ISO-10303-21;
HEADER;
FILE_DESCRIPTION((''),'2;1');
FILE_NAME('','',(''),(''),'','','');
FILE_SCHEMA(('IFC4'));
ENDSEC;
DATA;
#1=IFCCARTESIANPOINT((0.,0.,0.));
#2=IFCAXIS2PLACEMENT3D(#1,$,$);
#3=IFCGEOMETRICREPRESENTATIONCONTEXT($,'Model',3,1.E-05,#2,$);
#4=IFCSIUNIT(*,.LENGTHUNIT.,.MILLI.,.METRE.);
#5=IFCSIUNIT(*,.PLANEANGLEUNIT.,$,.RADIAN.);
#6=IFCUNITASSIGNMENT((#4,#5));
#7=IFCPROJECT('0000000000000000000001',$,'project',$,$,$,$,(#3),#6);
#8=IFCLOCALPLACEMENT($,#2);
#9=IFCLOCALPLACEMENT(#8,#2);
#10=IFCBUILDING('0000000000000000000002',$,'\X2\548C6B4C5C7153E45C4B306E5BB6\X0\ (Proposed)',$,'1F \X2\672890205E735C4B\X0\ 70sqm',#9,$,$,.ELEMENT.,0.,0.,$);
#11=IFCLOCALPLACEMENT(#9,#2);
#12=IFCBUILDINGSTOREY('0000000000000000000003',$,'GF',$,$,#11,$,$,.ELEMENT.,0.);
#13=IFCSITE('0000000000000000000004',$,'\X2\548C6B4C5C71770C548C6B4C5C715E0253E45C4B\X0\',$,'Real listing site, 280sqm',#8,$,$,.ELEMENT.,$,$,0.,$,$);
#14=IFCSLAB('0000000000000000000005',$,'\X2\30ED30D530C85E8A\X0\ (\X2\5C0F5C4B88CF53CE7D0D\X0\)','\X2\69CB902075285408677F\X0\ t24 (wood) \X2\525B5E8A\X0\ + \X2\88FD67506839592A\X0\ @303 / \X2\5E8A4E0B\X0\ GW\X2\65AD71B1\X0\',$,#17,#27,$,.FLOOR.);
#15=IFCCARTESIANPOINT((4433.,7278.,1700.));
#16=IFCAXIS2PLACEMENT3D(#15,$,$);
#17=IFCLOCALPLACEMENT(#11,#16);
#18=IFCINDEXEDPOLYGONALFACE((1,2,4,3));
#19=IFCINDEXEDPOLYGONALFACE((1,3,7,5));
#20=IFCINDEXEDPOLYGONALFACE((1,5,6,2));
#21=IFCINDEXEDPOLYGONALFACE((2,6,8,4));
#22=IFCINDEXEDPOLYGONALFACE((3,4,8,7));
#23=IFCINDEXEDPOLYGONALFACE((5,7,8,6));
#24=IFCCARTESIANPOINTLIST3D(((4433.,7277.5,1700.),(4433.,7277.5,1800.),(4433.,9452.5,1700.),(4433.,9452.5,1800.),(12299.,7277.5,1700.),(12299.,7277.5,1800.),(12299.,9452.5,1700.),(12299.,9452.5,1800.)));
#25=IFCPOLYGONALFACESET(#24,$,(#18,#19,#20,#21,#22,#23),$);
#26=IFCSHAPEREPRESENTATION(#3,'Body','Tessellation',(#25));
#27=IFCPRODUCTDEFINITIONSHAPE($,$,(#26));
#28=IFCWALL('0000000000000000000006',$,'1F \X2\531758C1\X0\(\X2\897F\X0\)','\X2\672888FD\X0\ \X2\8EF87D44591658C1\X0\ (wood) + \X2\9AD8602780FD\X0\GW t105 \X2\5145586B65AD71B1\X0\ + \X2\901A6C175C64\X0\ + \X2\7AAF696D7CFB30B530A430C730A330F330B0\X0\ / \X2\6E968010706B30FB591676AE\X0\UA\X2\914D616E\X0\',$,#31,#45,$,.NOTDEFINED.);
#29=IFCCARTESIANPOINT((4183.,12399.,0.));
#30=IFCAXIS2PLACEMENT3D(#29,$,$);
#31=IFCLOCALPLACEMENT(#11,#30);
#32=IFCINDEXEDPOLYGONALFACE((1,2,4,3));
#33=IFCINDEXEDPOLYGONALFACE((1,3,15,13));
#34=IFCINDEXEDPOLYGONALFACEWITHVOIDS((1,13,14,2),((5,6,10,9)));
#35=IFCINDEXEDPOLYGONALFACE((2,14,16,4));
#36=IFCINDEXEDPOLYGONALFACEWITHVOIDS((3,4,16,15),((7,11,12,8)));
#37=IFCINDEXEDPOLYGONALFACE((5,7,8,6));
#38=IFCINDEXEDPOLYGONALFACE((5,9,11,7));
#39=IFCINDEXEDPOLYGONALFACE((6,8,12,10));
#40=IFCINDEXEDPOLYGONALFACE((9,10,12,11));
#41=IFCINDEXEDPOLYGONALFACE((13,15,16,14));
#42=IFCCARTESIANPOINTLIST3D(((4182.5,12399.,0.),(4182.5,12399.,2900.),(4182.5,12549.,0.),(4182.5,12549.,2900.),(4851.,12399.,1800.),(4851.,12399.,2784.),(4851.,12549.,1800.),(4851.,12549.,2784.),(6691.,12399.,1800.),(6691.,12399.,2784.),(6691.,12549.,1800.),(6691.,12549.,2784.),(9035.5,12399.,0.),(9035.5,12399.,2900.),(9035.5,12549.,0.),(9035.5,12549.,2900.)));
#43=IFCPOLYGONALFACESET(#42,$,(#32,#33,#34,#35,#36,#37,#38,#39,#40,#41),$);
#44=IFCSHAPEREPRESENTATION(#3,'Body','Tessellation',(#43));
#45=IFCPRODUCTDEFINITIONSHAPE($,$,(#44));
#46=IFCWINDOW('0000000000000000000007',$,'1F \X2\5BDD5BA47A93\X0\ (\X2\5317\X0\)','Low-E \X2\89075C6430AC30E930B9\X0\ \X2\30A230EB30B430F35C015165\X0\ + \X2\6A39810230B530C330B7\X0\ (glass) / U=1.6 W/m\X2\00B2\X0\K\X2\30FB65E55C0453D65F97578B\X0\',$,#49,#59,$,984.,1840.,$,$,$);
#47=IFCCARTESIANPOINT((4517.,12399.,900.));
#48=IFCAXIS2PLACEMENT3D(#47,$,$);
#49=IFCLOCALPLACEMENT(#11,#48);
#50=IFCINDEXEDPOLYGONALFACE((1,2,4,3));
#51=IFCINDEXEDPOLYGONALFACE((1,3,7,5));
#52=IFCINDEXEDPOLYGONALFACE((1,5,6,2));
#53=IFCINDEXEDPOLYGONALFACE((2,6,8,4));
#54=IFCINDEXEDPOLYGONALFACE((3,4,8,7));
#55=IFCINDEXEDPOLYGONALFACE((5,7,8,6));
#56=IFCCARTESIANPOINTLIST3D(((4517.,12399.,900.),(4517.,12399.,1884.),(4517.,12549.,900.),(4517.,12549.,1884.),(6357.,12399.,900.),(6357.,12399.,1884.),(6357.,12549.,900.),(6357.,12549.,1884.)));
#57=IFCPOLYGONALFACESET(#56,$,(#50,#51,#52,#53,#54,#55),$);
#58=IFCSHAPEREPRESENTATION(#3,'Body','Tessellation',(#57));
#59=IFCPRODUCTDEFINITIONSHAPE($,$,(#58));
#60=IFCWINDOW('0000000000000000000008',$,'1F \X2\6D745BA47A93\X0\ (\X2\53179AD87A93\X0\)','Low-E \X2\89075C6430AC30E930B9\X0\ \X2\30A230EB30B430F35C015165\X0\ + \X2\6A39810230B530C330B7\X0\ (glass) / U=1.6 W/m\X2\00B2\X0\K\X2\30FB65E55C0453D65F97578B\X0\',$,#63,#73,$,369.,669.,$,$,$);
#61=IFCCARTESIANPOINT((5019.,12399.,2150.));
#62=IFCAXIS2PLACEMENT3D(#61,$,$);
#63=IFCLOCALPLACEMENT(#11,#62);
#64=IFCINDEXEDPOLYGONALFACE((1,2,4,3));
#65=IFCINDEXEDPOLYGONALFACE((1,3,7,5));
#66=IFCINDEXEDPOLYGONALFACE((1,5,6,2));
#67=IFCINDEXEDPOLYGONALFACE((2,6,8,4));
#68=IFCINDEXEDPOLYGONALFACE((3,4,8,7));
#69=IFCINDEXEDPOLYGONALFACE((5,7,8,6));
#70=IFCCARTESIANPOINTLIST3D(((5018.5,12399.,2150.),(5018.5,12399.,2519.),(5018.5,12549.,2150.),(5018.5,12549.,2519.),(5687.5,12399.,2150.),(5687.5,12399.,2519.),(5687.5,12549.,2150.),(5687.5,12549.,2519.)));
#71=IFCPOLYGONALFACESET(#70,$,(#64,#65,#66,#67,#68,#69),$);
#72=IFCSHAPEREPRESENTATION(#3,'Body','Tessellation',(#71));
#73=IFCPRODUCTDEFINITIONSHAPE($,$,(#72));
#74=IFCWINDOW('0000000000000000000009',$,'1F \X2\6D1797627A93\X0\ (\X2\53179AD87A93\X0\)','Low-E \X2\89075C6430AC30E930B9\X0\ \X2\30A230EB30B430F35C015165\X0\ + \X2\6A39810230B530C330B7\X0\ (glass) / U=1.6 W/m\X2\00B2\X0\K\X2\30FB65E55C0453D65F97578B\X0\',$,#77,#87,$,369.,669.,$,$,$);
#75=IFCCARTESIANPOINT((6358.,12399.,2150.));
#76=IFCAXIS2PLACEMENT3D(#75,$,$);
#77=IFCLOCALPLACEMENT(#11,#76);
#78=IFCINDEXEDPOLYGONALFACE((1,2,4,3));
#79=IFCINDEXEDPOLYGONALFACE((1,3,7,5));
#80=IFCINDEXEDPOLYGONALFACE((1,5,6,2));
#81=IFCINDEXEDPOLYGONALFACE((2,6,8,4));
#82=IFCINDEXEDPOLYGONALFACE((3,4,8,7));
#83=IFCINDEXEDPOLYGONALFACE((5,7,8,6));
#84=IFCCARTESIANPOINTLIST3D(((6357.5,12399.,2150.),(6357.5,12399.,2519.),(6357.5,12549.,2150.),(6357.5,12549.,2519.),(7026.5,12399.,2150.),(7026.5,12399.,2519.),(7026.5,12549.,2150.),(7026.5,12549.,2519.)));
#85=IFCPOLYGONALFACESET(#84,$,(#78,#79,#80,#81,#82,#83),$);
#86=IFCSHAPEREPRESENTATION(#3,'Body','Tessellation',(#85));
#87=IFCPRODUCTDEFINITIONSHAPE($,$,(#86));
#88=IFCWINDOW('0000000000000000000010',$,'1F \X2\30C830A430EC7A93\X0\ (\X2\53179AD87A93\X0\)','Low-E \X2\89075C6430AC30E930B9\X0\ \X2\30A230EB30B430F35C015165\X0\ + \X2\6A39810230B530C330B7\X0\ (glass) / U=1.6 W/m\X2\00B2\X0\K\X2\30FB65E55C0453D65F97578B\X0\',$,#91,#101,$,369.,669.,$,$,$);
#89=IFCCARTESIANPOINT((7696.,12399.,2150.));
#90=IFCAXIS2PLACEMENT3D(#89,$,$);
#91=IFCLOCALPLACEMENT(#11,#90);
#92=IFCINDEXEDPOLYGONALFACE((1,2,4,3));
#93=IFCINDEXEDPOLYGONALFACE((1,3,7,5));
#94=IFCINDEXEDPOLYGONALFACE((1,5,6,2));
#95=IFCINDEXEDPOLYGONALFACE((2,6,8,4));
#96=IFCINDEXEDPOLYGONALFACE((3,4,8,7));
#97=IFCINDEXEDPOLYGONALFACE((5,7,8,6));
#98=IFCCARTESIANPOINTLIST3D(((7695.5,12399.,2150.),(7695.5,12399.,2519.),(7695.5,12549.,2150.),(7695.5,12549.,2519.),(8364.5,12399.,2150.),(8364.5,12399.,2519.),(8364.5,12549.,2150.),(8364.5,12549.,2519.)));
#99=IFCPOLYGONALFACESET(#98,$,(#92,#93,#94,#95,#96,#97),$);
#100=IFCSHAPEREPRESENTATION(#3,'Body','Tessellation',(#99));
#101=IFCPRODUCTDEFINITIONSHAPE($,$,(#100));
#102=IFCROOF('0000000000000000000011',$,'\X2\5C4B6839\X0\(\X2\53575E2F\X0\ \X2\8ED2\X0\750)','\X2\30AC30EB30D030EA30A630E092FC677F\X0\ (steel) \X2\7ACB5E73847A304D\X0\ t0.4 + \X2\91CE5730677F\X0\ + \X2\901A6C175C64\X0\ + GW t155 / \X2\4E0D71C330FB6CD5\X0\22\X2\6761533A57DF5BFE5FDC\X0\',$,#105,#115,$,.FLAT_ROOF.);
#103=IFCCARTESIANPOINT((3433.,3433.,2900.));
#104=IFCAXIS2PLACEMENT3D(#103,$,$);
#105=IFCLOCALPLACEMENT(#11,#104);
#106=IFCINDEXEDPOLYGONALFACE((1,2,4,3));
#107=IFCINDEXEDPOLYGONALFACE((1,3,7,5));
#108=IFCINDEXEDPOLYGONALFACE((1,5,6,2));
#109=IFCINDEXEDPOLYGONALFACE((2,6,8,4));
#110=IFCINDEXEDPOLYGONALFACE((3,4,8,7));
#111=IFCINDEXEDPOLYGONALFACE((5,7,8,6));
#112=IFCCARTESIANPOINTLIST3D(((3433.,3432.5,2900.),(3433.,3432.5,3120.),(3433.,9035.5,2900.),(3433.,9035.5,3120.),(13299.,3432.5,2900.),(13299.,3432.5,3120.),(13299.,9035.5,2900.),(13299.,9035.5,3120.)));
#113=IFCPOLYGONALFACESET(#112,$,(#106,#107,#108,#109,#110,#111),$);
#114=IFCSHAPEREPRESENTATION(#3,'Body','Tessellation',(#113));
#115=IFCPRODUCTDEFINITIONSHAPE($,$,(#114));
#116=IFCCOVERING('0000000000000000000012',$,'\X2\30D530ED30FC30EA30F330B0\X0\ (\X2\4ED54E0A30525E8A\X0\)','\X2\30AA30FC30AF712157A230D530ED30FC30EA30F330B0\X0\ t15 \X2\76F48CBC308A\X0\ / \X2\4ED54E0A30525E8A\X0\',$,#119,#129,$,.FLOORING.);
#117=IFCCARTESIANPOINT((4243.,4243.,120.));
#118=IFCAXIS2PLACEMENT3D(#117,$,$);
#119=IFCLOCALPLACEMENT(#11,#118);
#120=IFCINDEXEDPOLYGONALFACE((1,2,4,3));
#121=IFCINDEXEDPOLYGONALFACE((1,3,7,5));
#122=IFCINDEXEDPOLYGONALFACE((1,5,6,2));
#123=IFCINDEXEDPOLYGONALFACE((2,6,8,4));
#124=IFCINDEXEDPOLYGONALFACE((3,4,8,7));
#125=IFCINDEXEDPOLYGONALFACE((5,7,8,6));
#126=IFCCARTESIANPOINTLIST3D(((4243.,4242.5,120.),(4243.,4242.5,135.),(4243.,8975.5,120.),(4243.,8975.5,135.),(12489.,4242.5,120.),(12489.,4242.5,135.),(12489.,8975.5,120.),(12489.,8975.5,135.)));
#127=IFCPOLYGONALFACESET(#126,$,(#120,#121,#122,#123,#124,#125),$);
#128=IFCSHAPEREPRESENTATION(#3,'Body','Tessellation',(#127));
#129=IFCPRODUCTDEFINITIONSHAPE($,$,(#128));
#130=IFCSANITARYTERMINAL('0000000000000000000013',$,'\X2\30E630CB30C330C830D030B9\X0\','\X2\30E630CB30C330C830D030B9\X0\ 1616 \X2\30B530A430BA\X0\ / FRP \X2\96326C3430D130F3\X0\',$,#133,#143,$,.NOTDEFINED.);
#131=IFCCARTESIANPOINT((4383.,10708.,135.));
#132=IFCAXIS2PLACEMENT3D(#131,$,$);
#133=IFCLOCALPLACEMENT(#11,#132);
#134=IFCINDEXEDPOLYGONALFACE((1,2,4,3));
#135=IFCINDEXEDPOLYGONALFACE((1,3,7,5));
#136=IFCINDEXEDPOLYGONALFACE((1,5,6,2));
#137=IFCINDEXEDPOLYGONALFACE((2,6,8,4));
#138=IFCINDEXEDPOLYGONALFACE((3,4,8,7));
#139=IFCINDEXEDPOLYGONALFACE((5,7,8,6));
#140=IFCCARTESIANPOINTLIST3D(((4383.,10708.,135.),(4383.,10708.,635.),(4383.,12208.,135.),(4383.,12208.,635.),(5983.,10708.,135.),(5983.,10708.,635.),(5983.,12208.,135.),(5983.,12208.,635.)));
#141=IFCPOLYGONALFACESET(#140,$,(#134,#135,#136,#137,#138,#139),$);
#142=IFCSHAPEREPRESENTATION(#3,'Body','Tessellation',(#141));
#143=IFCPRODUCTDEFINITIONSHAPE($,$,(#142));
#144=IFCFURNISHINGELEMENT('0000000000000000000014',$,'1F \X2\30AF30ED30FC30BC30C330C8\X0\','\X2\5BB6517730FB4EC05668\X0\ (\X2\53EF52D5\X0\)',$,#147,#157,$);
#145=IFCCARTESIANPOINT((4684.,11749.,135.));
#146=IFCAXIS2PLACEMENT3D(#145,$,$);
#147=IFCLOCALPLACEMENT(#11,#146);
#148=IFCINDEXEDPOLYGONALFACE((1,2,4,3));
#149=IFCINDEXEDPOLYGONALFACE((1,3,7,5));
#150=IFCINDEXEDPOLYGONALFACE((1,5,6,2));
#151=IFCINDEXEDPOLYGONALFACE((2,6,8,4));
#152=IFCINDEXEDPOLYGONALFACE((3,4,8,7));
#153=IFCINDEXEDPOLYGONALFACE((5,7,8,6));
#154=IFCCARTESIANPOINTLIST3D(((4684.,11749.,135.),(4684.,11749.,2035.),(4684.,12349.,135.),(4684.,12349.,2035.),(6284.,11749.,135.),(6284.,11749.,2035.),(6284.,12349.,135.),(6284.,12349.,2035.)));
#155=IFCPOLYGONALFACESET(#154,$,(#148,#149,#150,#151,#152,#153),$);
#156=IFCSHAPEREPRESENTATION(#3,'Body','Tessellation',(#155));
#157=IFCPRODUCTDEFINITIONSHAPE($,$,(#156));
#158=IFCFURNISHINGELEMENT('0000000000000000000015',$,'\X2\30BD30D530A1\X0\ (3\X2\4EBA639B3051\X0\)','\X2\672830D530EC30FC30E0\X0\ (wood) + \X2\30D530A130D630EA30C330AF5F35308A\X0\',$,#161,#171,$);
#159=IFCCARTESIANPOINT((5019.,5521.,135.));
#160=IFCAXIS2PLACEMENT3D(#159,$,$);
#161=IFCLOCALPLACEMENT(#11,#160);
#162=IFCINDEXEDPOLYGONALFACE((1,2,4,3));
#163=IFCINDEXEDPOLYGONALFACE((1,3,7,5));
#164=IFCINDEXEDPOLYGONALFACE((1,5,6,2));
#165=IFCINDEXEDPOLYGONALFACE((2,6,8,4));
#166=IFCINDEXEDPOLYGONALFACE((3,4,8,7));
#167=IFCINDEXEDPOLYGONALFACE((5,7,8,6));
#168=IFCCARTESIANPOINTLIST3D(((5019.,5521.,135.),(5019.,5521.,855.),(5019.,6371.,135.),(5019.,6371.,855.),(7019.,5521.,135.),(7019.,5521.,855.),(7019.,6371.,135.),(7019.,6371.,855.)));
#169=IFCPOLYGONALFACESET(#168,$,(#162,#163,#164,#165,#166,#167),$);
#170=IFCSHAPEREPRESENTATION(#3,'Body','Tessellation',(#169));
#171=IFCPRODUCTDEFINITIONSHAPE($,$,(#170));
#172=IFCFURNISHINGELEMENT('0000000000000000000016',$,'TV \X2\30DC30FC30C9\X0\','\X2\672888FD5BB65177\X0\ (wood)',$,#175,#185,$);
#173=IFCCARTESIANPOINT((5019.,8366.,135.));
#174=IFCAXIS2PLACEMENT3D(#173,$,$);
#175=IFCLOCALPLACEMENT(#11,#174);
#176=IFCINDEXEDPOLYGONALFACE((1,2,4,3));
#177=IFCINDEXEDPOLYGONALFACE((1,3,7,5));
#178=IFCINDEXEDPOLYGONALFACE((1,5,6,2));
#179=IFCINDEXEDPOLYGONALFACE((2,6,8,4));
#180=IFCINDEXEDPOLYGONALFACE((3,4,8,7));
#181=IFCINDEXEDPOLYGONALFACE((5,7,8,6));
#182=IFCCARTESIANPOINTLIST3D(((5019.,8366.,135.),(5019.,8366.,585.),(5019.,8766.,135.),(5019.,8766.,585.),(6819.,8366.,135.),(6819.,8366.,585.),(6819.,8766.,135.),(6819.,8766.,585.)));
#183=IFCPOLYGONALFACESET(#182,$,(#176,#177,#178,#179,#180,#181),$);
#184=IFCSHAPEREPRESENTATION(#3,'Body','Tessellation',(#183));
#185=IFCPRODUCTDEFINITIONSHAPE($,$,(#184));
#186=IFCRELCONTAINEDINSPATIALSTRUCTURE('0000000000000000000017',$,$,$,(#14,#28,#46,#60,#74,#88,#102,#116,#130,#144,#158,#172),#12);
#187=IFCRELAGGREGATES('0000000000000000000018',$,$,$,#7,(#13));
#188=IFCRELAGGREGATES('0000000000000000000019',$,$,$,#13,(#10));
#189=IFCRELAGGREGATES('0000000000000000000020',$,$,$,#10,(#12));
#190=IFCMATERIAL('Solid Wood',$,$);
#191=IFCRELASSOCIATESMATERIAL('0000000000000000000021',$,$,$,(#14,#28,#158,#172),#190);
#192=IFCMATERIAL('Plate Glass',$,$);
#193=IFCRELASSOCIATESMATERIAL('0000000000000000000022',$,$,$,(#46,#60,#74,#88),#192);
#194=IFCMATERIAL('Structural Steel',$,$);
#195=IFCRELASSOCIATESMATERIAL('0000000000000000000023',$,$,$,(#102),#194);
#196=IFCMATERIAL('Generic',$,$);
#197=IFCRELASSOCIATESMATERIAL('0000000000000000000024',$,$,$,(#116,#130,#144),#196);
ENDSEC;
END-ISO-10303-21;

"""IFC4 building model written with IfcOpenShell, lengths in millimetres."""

from ifc_helpers import new_model, si_unit, frame, frame_2d, origin, place, context, project, spatial, rectangle, extrude, material, element, fill, save


model = new_model("IFC4")

# Units and contexts
model_context = context("Model", 3, precision=1e-05, world=origin())
ifc_project = project(units=[si_unit("LENGTHUNIT", "METRE", prefix="MILLI"), si_unit("PLANEANGLEUNIT", "RADIAN")], contexts=[model_context])

# Site, building, storey
site_placement = place(None, origin())
site = spatial("IfcSite", under=ifc_project, at=site_placement, Name="和歌山県和歌山市古屋", ObjectType="Real listing site, 280sqm", CompositionType="ELEMENT", RefElevation=0.0)
building_placement = place(site_placement, origin())
building = spatial("IfcBuilding", under=site, at=building_placement, Name="和歌山古屋の家 (Proposed)", ObjectType="1F 木造平屋 70sqm", CompositionType="ELEMENT", ElevationOfRefHeight=0.0, ElevationOfTerrain=0.0)
storey_placement = place(building_placement, origin())
storey = spatial("IfcBuildingStorey", under=building, at=storey_placement, Name="GF", CompositionType="ELEMENT", Elevation=0.0)

# Slab
ifc_material_1 = material(Name="Solid Wood")
slab_1_placement = place(storey_placement, frame((4433.0, 7278.0, 1700.0)))
element("IfcSlab", 1, at=slab_1_placement, inside=storey, material=ifc_material_1, Name="ロフト床 (小屋裏収納)", Description="構造用合板 t24 (wood) 剛床 + 製材根太 @303 / 床下 GW断熱", PredefinedType="FLOOR", context=model_context, shape_type="SweptSolid", body=[
    extrude(rectangle(XDim=7866.0, YDim=2175.0, at=frame_2d((3933.0, 1087.0))), frame((4433.0, 7278.0, 1700.0)), (0.0, 0.0, 1.0), 100.0),
])

# Shared definitions
ifc_material_2 = material(Name="Plate Glass")

# Wall, openings, windows
wall_1_placement = place(storey_placement, frame((4183.0, 12399.0, 0.0)))
wall_1 = element("IfcWall", 2, at=wall_1_placement, inside=storey, material=ifc_material_1, Name="1F 北壁(西)", Description="木製 軸組外壁 (wood) + 高性能GW t105 充填断熱 + 通気層 + 窯業系サイディング / 準耐火・外皮UA配慮", PredefinedType="NOTDEFINED", context=model_context, shape_type="SweptSolid", body=[
    extrude(rectangle(XDim=4853.0, YDim=150.0, at=frame_2d((2426.0, 75.0))), frame((4183.0, 12399.0, 0.0)), (0.0, 0.0, 1.0), 2900.0),
])
opening_1_placement = place(storey_placement, frame((4517.0, 12399.0, 900.0)))
opening_1 = element("IfcOpeningElement", 3, at=opening_1_placement, cuts=wall_1, PredefinedType="NOTDEFINED", context=model_context, shape_type="SweptSolid", body=[
    extrude(rectangle(XDim=1840.0, YDim=150.0, at=frame_2d((920.0, 75.0))), frame((4517.0, 12399.0, 900.0)), (0.0, 0.0, 1.0), 984.0),
])
opening_2_placement = place(storey_placement, frame((5019.0, 12399.0, 2150.0)))
opening_2 = element("IfcOpeningElement", 4, at=opening_2_placement, cuts=wall_1, PredefinedType="NOTDEFINED", context=model_context, shape_type="SweptSolid", body=[
    extrude(rectangle(XDim=669.0, YDim=150.0, at=frame_2d((334.0, 75.0))), frame((5019.0, 12399.0, 2150.0)), (0.0, 0.0, 1.0), 369.0),
])
opening_3_placement = place(storey_placement, frame((6358.0, 12399.0, 2150.0)))
opening_3 = element("IfcOpeningElement", 5, at=opening_3_placement, cuts=wall_1, PredefinedType="NOTDEFINED", context=model_context, shape_type="SweptSolid", body=[
    extrude(rectangle(XDim=669.0, YDim=150.0, at=frame_2d((334.0, 75.0))), frame((6358.0, 12399.0, 2150.0)), (0.0, 0.0, 1.0), 369.0),
])
opening_4_placement = place(storey_placement, frame((7696.0, 12399.0, 2150.0)))
opening_4 = element("IfcOpeningElement", 6, at=opening_4_placement, cuts=wall_1, PredefinedType="NOTDEFINED", context=model_context, shape_type="SweptSolid", body=[
    extrude(rectangle(XDim=669.0, YDim=150.0, at=frame_2d((334.0, 75.0))), frame((7696.0, 12399.0, 2150.0)), (0.0, 0.0, 1.0), 369.0),
])
window_1_placement = place(storey_placement, frame((4517.0, 12399.0, 900.0)))
window_1 = element("IfcWindow", 7, at=window_1_placement, inside=storey, material=ifc_material_2, Name="1F 寝室窓 (北)", Description="Low-E 複層ガラス アルゴン封入 + 樹脂サッシ (glass) / U=1.6 W/m²K・日射取得型", OverallHeight=984.0, OverallWidth=1840.0, context=model_context, shape_type="SweptSolid", body=[
    extrude(rectangle(XDim=1840.0, YDim=150.0, at=frame_2d((920.0, 75.0))), frame((4517.0, 12399.0, 900.0)), (0.0, 0.0, 1.0), 984.0),
])
fill(opening_1, window_1)
window_2_placement = place(storey_placement, frame((5019.0, 12399.0, 2150.0)))
window_2 = element("IfcWindow", 8, at=window_2_placement, inside=storey, material=ifc_material_2, Name="1F 浴室窓 (北高窓)", Description="Low-E 複層ガラス アルゴン封入 + 樹脂サッシ (glass) / U=1.6 W/m²K・日射取得型", OverallHeight=369.0, OverallWidth=669.0, context=model_context, shape_type="SweptSolid", body=[
    extrude(rectangle(XDim=669.0, YDim=150.0, at=frame_2d((334.0, 75.0))), frame((5019.0, 12399.0, 2150.0)), (0.0, 0.0, 1.0), 369.0),
])
fill(opening_2, window_2)
window_3_placement = place(storey_placement, frame((6358.0, 12399.0, 2150.0)))
window_3 = element("IfcWindow", 9, at=window_3_placement, inside=storey, material=ifc_material_2, Name="1F 洗面窓 (北高窓)", Description="Low-E 複層ガラス アルゴン封入 + 樹脂サッシ (glass) / U=1.6 W/m²K・日射取得型", OverallHeight=369.0, OverallWidth=669.0, context=model_context, shape_type="SweptSolid", body=[
    extrude(rectangle(XDim=669.0, YDim=150.0, at=frame_2d((334.0, 75.0))), frame((6358.0, 12399.0, 2150.0)), (0.0, 0.0, 1.0), 369.0),
])
fill(opening_3, window_3)
window_4_placement = place(storey_placement, frame((7696.0, 12399.0, 2150.0)))
window_4 = element("IfcWindow", 10, at=window_4_placement, inside=storey, material=ifc_material_2, Name="1F トイレ窓 (北高窓)", Description="Low-E 複層ガラス アルゴン封入 + 樹脂サッシ (glass) / U=1.6 W/m²K・日射取得型", OverallHeight=369.0, OverallWidth=669.0, context=model_context, shape_type="SweptSolid", body=[
    extrude(rectangle(XDim=669.0, YDim=150.0, at=frame_2d((334.0, 75.0))), frame((7696.0, 12399.0, 2150.0)), (0.0, 0.0, 1.0), 369.0),
])
fill(opening_4, window_4)

# Roof
ifc_material_3 = material(Name="Structural Steel")
roof_1_placement = place(storey_placement, frame((3433.0, 3433.0, 2900.0)))
element("IfcRoof", 11, at=roof_1_placement, inside=storey, material=ifc_material_3, Name="屋根(南帯 軒750)", Description="ガルバリウム鋼板 (steel) 立平葺き t0.4 + 野地板 + 通気層 + GW t155 / 不燃・法22条区域対応", PredefinedType="FLAT_ROOF", context=model_context, shape_type="SweptSolid", body=[
    extrude(rectangle(XDim=9866.0, YDim=5603.0, at=frame_2d((4933.0, 2801.0))), frame((3433.0, 3433.0, 2900.0)), (0.0, 0.0, 1.0), 220.0),
])

# Covering
ifc_material_4 = material(Name="Generic")
covering_1_placement = place(storey_placement, frame((4243.0, 4243.0, 120.0)))
element("IfcCovering", 12, at=covering_1_placement, inside=storey, material=ifc_material_4, Name="フローリング (仕上げ床)", Description="オーク無垢フローリング t15 直貼り / 仕上げ床", PredefinedType="FLOORING", context=model_context, shape_type="SweptSolid", body=[
    extrude(rectangle(XDim=8246.0, YDim=4733.0, at=frame_2d((4123.0, 2366.0))), frame((4243.0, 4243.0, 120.0)), (0.0, 0.0, 1.0), 15.0),
])

# Sanitary terminal
sanitary_terminal_placement = place(storey_placement, frame((4383.0, 10708.0, 135.0)))
element("IfcSanitaryTerminal", 13, at=sanitary_terminal_placement, inside=storey, material=ifc_material_4, Name="ユニットバス", Description="ユニットバス 1616 サイズ / FRP 防水パン", PredefinedType="NOTDEFINED", context=model_context, shape_type="SweptSolid", body=[
    extrude(rectangle(XDim=1600.0, YDim=1500.0, at=frame_2d((800.0, 750.0))), frame((4383.0, 10708.0, 135.0)), (0.0, 0.0, 1.0), 500.0),
])

# Furnishing elements
furnishing_1_placement = place(storey_placement, frame((4684.0, 11749.0, 135.0)))
element("IfcFurnishingElement", 14, at=furnishing_1_placement, inside=storey, material=ifc_material_4, Name="1F クローゼット", Description="家具・什器 (可動)", context=model_context, shape_type="SweptSolid", body=[
    extrude(rectangle(XDim=1600.0, YDim=600.0, at=frame_2d((800.0, 300.0))), frame((4684.0, 11749.0, 135.0)), (0.0, 0.0, 1.0), 1900.0),
])
furnishing_2_placement = place(storey_placement, frame((5019.0, 5521.0, 135.0)))
element("IfcFurnishingElement", 15, at=furnishing_2_placement, inside=storey, material=ifc_material_1, Name="ソファ (3人掛け)", Description="木フレーム (wood) + ファブリック張り", context=model_context, shape_type="SweptSolid", body=[
    extrude(rectangle(XDim=2000.0, YDim=850.0, at=frame_2d((1000.0, 425.0))), frame((5019.0, 5521.0, 135.0)), (0.0, 0.0, 1.0), 720.0),
])
furnishing_3_placement = place(storey_placement, frame((5019.0, 8366.0, 135.0)))
element("IfcFurnishingElement", 16, at=furnishing_3_placement, inside=storey, material=ifc_material_1, Name="TV ボード", Description="木製家具 (wood)", context=model_context, shape_type="SweptSolid", body=[
    extrude(rectangle(XDim=1800.0, YDim=400.0, at=frame_2d((900.0, 200.0))), frame((5019.0, 8366.0, 135.0)), (0.0, 0.0, 1.0), 450.0),
])

save(model, "model.ifc")
